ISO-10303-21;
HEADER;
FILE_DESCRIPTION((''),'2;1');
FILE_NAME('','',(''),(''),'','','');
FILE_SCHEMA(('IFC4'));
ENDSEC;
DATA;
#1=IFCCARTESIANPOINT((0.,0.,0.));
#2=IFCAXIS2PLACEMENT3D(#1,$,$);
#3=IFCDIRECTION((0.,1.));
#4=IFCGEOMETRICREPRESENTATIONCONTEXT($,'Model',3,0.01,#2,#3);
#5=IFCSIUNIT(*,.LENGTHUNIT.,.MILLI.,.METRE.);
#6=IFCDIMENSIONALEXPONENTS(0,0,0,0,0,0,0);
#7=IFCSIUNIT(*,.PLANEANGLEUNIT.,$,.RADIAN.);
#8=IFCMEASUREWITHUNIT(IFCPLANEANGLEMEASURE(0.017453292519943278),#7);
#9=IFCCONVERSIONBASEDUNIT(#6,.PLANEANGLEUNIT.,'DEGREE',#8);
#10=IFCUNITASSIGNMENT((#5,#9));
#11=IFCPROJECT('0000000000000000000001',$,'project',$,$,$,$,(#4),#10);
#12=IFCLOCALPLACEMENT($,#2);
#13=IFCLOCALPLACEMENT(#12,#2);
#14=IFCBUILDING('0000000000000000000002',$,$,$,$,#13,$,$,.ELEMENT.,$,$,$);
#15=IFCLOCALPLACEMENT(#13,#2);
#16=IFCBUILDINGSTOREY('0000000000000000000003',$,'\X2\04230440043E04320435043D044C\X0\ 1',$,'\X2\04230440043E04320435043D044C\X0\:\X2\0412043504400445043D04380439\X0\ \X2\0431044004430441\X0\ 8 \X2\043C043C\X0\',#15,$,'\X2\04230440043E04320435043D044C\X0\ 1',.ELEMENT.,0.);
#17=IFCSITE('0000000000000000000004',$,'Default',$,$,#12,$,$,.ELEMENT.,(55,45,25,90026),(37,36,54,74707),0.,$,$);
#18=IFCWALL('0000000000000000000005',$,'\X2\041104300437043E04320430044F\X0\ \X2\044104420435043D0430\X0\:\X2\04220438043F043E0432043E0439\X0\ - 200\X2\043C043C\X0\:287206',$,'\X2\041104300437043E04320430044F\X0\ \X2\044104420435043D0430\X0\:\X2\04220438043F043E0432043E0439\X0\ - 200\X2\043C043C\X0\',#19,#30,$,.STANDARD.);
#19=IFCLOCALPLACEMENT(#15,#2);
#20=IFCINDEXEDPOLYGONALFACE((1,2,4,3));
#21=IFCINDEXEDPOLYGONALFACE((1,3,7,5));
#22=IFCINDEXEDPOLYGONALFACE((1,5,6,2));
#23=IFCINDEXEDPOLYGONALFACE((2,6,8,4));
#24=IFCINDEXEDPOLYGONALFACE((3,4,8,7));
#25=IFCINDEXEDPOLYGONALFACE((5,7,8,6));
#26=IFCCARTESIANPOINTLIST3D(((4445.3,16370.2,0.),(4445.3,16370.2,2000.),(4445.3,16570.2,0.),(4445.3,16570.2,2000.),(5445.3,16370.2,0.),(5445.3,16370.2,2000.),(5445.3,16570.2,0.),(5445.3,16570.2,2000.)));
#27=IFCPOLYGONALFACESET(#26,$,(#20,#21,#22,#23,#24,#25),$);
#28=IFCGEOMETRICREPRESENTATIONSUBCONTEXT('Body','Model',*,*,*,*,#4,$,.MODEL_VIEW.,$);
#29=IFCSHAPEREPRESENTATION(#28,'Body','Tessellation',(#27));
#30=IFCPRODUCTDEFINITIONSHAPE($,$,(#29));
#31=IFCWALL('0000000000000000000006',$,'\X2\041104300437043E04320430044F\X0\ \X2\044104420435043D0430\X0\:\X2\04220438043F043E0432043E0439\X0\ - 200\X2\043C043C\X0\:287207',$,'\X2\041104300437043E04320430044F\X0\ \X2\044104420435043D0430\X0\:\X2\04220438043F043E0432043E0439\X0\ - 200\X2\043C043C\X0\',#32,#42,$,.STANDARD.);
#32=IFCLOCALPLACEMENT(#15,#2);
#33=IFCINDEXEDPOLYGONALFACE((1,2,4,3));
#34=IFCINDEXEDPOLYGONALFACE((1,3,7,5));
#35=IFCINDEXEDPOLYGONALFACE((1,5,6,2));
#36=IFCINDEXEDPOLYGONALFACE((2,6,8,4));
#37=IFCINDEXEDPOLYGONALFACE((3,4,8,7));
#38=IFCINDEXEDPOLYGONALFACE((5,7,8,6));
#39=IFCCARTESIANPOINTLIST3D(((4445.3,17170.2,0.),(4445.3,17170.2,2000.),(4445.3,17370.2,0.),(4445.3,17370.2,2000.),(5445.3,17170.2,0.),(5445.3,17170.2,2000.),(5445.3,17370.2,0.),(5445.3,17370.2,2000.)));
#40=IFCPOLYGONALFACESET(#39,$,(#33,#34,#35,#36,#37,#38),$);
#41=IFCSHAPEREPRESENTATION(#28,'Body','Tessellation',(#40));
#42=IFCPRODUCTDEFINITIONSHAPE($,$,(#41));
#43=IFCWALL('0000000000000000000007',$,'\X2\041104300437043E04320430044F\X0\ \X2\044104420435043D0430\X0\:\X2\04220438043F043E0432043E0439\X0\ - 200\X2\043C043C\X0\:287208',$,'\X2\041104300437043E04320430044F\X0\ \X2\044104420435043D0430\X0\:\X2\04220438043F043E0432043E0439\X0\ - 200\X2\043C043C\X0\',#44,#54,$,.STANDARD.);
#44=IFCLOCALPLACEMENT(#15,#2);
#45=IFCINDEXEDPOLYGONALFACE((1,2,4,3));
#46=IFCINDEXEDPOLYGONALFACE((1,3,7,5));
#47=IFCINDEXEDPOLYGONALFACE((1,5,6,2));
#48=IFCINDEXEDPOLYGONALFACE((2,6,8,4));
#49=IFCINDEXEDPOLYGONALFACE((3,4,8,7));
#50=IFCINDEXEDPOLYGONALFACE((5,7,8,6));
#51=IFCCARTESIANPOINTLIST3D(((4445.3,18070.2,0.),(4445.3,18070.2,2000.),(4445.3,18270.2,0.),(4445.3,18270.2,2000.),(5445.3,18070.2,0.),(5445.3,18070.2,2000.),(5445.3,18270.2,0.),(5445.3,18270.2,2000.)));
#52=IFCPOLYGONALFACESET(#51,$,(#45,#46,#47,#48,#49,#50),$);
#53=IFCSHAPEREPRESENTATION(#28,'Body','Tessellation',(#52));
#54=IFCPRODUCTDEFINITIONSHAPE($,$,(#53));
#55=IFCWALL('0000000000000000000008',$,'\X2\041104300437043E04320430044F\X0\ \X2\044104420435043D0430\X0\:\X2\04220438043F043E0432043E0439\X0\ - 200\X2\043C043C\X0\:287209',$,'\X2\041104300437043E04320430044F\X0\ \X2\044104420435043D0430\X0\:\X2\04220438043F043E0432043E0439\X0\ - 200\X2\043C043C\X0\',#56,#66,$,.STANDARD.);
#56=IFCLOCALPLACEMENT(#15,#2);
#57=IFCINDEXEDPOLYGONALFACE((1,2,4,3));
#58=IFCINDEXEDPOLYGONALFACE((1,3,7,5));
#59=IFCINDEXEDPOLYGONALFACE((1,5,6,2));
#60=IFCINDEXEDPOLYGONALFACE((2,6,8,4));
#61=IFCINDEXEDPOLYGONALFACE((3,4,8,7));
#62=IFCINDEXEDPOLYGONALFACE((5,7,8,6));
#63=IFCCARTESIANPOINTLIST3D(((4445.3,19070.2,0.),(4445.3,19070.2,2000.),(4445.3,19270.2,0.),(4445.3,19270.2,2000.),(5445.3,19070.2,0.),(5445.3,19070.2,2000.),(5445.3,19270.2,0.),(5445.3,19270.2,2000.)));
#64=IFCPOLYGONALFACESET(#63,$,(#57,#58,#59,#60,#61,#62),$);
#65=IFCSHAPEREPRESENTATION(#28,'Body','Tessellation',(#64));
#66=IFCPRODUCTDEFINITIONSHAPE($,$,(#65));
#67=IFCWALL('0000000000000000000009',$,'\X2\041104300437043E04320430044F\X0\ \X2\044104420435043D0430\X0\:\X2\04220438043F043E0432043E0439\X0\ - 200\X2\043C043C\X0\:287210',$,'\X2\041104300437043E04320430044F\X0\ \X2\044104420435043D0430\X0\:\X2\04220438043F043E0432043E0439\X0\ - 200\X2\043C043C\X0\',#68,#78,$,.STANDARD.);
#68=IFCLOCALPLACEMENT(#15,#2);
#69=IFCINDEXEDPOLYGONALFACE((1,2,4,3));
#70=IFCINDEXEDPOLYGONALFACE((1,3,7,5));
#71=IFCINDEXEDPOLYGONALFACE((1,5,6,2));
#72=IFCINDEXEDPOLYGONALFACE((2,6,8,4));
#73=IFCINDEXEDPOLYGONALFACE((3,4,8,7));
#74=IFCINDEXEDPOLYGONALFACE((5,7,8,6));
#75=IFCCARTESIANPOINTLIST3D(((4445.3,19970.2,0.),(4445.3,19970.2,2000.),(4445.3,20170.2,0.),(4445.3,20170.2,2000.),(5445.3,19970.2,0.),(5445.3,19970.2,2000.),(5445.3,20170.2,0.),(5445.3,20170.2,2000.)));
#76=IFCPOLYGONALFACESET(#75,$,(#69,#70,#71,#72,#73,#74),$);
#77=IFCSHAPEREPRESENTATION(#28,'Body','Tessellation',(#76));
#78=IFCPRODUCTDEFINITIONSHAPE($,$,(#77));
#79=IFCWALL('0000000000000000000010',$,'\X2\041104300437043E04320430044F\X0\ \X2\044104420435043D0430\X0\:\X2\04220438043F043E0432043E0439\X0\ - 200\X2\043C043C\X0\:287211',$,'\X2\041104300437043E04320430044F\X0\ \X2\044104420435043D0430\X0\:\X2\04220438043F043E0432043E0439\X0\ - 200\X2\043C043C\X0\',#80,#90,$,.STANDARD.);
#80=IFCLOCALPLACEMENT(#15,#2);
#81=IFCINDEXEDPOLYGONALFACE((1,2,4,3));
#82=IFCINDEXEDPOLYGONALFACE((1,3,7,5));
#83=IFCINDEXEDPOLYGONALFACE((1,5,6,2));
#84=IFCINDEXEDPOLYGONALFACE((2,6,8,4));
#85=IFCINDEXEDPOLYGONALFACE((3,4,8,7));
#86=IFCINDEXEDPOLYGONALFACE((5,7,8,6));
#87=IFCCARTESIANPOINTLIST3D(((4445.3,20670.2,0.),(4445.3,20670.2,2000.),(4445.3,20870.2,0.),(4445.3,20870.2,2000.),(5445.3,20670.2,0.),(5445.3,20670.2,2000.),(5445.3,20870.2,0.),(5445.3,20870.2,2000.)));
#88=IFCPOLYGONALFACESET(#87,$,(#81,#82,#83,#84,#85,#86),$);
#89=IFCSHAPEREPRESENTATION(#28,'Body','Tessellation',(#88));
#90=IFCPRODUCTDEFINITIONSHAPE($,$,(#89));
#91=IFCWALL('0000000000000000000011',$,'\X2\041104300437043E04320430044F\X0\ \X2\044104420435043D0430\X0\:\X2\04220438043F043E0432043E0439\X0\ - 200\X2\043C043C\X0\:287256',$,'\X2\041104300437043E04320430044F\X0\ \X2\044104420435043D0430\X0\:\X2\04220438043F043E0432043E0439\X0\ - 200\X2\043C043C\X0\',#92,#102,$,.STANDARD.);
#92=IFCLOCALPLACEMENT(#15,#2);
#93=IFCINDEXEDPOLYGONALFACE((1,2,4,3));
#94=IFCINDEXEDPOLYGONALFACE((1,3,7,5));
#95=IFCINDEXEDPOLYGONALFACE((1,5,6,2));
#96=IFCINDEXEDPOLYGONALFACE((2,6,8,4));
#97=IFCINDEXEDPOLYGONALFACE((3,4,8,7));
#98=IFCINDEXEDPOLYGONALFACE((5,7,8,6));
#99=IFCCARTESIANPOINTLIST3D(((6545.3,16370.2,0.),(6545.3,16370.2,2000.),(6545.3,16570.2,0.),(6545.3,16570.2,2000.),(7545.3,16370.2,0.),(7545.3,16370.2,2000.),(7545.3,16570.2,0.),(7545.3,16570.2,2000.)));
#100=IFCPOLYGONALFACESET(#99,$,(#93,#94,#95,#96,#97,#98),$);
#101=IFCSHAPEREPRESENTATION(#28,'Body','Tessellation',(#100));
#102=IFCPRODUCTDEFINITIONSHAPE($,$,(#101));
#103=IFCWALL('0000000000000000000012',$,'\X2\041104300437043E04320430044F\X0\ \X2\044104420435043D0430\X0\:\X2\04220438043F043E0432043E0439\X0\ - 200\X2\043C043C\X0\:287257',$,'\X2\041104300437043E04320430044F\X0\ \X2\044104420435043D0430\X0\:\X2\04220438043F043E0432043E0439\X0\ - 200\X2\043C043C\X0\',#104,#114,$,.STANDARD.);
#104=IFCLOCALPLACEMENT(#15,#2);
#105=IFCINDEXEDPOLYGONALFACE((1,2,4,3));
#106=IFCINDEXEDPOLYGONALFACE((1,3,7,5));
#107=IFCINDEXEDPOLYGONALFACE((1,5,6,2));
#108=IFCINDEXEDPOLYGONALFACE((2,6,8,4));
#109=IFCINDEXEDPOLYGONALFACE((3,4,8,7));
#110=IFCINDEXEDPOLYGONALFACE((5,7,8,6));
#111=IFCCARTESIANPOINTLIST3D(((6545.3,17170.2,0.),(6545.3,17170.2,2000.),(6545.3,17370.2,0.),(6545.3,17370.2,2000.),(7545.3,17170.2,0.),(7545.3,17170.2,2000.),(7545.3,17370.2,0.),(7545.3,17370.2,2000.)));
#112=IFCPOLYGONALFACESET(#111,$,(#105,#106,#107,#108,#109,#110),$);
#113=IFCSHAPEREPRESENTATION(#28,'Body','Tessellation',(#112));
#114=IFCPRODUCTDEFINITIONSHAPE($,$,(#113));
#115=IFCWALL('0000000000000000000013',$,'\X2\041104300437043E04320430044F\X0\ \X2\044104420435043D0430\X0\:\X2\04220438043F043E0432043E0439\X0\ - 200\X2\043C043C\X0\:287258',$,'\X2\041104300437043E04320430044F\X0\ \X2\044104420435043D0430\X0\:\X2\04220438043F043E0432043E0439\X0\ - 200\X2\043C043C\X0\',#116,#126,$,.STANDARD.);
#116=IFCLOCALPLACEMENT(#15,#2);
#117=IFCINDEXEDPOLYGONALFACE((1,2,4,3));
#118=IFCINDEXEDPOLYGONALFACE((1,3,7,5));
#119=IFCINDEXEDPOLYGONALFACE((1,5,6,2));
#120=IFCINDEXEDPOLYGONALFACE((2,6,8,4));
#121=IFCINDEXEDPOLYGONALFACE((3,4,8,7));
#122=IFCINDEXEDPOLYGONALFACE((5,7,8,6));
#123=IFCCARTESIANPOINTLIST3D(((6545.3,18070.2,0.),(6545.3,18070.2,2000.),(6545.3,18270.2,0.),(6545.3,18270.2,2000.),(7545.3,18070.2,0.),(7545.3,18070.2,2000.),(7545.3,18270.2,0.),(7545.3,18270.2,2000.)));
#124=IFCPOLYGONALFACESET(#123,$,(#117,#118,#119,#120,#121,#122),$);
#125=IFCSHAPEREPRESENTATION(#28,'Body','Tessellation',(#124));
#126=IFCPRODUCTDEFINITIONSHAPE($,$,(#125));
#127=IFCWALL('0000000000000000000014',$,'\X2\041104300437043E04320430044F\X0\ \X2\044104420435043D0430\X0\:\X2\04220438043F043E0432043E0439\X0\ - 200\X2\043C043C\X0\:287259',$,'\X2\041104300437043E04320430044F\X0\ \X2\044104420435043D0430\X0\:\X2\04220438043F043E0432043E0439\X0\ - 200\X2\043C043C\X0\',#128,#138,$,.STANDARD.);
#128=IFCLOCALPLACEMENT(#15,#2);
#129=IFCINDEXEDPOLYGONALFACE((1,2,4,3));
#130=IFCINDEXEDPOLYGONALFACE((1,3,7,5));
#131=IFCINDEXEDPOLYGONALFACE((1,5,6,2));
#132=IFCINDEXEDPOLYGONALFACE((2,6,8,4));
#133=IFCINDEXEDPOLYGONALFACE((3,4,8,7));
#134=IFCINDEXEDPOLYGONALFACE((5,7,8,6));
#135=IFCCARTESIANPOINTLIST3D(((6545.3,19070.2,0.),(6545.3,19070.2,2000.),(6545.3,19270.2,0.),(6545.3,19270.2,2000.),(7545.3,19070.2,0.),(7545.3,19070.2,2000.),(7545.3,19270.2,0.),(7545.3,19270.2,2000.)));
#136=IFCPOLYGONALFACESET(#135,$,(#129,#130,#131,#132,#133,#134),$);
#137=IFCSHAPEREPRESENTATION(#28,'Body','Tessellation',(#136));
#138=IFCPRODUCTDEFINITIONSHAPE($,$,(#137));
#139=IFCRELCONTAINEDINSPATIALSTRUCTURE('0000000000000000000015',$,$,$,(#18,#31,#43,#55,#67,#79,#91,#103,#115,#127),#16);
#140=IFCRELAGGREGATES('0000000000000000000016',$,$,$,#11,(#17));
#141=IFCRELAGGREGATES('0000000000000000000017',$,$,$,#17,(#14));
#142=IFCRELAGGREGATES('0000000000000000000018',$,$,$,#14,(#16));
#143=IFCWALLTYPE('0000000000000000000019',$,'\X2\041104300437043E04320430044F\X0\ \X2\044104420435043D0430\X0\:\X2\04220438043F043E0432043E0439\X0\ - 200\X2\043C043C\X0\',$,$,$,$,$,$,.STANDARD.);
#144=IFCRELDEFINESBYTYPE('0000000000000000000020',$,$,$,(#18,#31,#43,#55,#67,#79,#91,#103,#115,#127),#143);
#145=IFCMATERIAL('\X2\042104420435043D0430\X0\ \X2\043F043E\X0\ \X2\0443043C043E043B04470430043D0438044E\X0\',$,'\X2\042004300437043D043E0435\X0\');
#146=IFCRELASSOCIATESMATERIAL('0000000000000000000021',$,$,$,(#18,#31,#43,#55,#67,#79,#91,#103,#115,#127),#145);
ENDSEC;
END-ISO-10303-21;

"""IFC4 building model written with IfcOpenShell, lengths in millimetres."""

from ifc_helpers import new_model, entity, si_unit, converted_unit, direction, frame, origin, place, context, subcontext, project, spatial, indexed_curve, outline, extrude, material, type_object, element, save


model = new_model("IFC4")

# Units and contexts
model_context = context("Model", 3, precision=0.01, world=origin(), true_north=direction((0.0, 1.0)))
body_context = subcontext(model_context, "Body", "Model", "MODEL_VIEW")
ifc_project = project(units=[si_unit("LENGTHUNIT", "METRE", prefix="MILLI"), converted_unit("PLANEANGLEUNIT", "DEGREE", entity("IfcPlaneAngleMeasure", 0.017453292519943278), si_unit("PLANEANGLEUNIT", "RADIAN"), dimensions=[0, 0, 0, 0, 0, 0, 0])], contexts=[model_context])

# Site, building, storey
site_placement = place(None, origin())
site = spatial("IfcSite", under=ifc_project, at=site_placement, Name="Default", CompositionType="ELEMENT", RefLatitude=(55, 45, 25, 90026), RefLongitude=(37, 36, 54, 74707), RefElevation=0.0)
building_placement = place(site_placement, origin())
building = spatial("IfcBuilding", under=site, at=building_placement, CompositionType="ELEMENT")
storey_placement = place(building_placement, origin())
storey = spatial("IfcBuildingStorey", under=building, at=storey_placement, Name="Уровень 1", ObjectType="Уровень:Верхний брус 8 мм", LongName="Уровень 1", CompositionType="ELEMENT", Elevation=0.0)

# Walls
ifc_material = material(Name="Стена по умолчанию", Category="Разное")
wall_type = type_object("IfcWallType", Name="Базовая стена:Типовой - 200мм", PredefinedType="STANDARD")
wall_1_placement = place(storey_placement, frame((4445.3, 16470.2, 0.0)))
element("IfcWall", 1, at=wall_1_placement, inside=storey, type_object=wall_type, material=ifc_material, Name="Базовая стена:Типовой - 200мм:287206", ObjectType="Базовая стена:Типовой - 200мм", PredefinedType="STANDARD", context=body_context, shape_type="SweptSolid", body=[
    extrude(outline(indexed_curve([(1000.0, 100.0), (0.0, 100.0), (0.0, -100.0), (1000.0, -100.0), (1000.0, 100.0)], self_intersect=False)), origin(), (0.0, 0.0, 1.0), 2000.0),
])
wall_2_placement = place(storey_placement, frame((4445.3, 17270.2, 0.0)))
element("IfcWall", 2, at=wall_2_placement, inside=storey, type_object=wall_type, material=ifc_material, Name="Базовая стена:Типовой - 200мм:287207", ObjectType="Базовая стена:Типовой - 200мм", PredefinedType="STANDARD", context=body_context, shape_type="SweptSolid", body=[
    extrude(outline(indexed_curve([(1000.0, 100.0), (0.0, 100.0), (0.0, -100.0), (1000.0, -100.0), (1000.0, 100.0)], self_intersect=False)), origin(), (0.0, 0.0, 1.0), 2000.0),
])
for number, where, name in (
    (3, (4445.3, 18170.2, 0.0), "Базовая стена:Типовой - 200мм:287208"),
    (4, (4445.3, 19170.2, 0.0), "Базовая стена:Типовой - 200мм:287209"),
):
    element("IfcWall", number, at=place(storey_placement, frame(where)), inside=storey, type_object=wall_type, material=ifc_material, Name=name, ObjectType="Базовая стена:Типовой - 200мм", PredefinedType="STANDARD", context=body_context, shape_type="SweptSolid", body=[
        extrude(outline(indexed_curve([(1000.0, 100.0), (0.0, 100.0), (0.0, -100.0), (1000.0, -100.0), (1000.0, 100.0)], self_intersect=False)), origin(), (0.0, 0.0, 1.0), 2000.0),
    ])
for number, where, name in (
    (5, (4445.3, 20070.2, 0.0), "Базовая стена:Типовой - 200мм:287210"),
    (6, (4445.3, 20770.2, 0.0), "Базовая стена:Типовой - 200мм:287211"),
):
    element("IfcWall", number, at=place(storey_placement, frame(where)), inside=storey, type_object=wall_type, material=ifc_material, Name=name, ObjectType="Базовая стена:Типовой - 200мм", PredefinedType="STANDARD", context=body_context, shape_type="SweptSolid", body=[
        extrude(outline(indexed_curve([(1000.0, 100.0), (0.0, 100.0), (0.0, -100.0), (1000.0, -100.0), (1000.0, 100.0)], self_intersect=False)), origin(), (0.0, 0.0, 1.0), 2000.0),
    ])
wall_3_placement = place(storey_placement, frame((6545.3, 16470.2, 0.0)))
element("IfcWall", 7, at=wall_3_placement, inside=storey, type_object=wall_type, material=ifc_material, Name="Базовая стена:Типовой - 200мм:287256", ObjectType="Базовая стена:Типовой - 200мм", PredefinedType="STANDARD", context=body_context, shape_type="SweptSolid", body=[
    extrude(outline(indexed_curve([(1000.0, 100.0), (0.0, 100.0), (0.0, -100.0), (1000.0, -100.0), (1000.0, 100.0)], self_intersect=False)), origin(), (0.0, 0.0, 1.0), 2000.0),
])
wall_4_placement = place(storey_placement, frame((6545.3, 17270.2, 0.0)))
element("IfcWall", 8, at=wall_4_placement, inside=storey, type_object=wall_type, material=ifc_material, Name="Базовая стена:Типовой - 200мм:287257", ObjectType="Базовая стена:Типовой - 200мм", PredefinedType="STANDARD", context=body_context, shape_type="SweptSolid", body=[
    extrude(outline(indexed_curve([(1000.0, 100.0), (0.0, 100.0), (0.0, -100.0), (1000.0, -100.0), (1000.0, 100.0)], self_intersect=False)), origin(), (0.0, 0.0, 1.0), 2000.0),
])
for number, where, name in (
    (9, (6545.3, 18170.2, 0.0), "Базовая стена:Типовой - 200мм:287258"),
    (10, (6545.3, 19170.2, 0.0), "Базовая стена:Типовой - 200мм:287259"),
):
    element("IfcWall", number, at=place(storey_placement, frame(where)), inside=storey, type_object=wall_type, material=ifc_material, Name=name, ObjectType="Базовая стена:Типовой - 200мм", PredefinedType="STANDARD", context=body_context, shape_type="SweptSolid", body=[
        extrude(outline(indexed_curve([(1000.0, 100.0), (0.0, 100.0), (0.0, -100.0), (1000.0, -100.0), (1000.0, 100.0)], self_intersect=False)), origin(), (0.0, 0.0, 1.0), 2000.0),
    ])

save(model, "model.ifc")
